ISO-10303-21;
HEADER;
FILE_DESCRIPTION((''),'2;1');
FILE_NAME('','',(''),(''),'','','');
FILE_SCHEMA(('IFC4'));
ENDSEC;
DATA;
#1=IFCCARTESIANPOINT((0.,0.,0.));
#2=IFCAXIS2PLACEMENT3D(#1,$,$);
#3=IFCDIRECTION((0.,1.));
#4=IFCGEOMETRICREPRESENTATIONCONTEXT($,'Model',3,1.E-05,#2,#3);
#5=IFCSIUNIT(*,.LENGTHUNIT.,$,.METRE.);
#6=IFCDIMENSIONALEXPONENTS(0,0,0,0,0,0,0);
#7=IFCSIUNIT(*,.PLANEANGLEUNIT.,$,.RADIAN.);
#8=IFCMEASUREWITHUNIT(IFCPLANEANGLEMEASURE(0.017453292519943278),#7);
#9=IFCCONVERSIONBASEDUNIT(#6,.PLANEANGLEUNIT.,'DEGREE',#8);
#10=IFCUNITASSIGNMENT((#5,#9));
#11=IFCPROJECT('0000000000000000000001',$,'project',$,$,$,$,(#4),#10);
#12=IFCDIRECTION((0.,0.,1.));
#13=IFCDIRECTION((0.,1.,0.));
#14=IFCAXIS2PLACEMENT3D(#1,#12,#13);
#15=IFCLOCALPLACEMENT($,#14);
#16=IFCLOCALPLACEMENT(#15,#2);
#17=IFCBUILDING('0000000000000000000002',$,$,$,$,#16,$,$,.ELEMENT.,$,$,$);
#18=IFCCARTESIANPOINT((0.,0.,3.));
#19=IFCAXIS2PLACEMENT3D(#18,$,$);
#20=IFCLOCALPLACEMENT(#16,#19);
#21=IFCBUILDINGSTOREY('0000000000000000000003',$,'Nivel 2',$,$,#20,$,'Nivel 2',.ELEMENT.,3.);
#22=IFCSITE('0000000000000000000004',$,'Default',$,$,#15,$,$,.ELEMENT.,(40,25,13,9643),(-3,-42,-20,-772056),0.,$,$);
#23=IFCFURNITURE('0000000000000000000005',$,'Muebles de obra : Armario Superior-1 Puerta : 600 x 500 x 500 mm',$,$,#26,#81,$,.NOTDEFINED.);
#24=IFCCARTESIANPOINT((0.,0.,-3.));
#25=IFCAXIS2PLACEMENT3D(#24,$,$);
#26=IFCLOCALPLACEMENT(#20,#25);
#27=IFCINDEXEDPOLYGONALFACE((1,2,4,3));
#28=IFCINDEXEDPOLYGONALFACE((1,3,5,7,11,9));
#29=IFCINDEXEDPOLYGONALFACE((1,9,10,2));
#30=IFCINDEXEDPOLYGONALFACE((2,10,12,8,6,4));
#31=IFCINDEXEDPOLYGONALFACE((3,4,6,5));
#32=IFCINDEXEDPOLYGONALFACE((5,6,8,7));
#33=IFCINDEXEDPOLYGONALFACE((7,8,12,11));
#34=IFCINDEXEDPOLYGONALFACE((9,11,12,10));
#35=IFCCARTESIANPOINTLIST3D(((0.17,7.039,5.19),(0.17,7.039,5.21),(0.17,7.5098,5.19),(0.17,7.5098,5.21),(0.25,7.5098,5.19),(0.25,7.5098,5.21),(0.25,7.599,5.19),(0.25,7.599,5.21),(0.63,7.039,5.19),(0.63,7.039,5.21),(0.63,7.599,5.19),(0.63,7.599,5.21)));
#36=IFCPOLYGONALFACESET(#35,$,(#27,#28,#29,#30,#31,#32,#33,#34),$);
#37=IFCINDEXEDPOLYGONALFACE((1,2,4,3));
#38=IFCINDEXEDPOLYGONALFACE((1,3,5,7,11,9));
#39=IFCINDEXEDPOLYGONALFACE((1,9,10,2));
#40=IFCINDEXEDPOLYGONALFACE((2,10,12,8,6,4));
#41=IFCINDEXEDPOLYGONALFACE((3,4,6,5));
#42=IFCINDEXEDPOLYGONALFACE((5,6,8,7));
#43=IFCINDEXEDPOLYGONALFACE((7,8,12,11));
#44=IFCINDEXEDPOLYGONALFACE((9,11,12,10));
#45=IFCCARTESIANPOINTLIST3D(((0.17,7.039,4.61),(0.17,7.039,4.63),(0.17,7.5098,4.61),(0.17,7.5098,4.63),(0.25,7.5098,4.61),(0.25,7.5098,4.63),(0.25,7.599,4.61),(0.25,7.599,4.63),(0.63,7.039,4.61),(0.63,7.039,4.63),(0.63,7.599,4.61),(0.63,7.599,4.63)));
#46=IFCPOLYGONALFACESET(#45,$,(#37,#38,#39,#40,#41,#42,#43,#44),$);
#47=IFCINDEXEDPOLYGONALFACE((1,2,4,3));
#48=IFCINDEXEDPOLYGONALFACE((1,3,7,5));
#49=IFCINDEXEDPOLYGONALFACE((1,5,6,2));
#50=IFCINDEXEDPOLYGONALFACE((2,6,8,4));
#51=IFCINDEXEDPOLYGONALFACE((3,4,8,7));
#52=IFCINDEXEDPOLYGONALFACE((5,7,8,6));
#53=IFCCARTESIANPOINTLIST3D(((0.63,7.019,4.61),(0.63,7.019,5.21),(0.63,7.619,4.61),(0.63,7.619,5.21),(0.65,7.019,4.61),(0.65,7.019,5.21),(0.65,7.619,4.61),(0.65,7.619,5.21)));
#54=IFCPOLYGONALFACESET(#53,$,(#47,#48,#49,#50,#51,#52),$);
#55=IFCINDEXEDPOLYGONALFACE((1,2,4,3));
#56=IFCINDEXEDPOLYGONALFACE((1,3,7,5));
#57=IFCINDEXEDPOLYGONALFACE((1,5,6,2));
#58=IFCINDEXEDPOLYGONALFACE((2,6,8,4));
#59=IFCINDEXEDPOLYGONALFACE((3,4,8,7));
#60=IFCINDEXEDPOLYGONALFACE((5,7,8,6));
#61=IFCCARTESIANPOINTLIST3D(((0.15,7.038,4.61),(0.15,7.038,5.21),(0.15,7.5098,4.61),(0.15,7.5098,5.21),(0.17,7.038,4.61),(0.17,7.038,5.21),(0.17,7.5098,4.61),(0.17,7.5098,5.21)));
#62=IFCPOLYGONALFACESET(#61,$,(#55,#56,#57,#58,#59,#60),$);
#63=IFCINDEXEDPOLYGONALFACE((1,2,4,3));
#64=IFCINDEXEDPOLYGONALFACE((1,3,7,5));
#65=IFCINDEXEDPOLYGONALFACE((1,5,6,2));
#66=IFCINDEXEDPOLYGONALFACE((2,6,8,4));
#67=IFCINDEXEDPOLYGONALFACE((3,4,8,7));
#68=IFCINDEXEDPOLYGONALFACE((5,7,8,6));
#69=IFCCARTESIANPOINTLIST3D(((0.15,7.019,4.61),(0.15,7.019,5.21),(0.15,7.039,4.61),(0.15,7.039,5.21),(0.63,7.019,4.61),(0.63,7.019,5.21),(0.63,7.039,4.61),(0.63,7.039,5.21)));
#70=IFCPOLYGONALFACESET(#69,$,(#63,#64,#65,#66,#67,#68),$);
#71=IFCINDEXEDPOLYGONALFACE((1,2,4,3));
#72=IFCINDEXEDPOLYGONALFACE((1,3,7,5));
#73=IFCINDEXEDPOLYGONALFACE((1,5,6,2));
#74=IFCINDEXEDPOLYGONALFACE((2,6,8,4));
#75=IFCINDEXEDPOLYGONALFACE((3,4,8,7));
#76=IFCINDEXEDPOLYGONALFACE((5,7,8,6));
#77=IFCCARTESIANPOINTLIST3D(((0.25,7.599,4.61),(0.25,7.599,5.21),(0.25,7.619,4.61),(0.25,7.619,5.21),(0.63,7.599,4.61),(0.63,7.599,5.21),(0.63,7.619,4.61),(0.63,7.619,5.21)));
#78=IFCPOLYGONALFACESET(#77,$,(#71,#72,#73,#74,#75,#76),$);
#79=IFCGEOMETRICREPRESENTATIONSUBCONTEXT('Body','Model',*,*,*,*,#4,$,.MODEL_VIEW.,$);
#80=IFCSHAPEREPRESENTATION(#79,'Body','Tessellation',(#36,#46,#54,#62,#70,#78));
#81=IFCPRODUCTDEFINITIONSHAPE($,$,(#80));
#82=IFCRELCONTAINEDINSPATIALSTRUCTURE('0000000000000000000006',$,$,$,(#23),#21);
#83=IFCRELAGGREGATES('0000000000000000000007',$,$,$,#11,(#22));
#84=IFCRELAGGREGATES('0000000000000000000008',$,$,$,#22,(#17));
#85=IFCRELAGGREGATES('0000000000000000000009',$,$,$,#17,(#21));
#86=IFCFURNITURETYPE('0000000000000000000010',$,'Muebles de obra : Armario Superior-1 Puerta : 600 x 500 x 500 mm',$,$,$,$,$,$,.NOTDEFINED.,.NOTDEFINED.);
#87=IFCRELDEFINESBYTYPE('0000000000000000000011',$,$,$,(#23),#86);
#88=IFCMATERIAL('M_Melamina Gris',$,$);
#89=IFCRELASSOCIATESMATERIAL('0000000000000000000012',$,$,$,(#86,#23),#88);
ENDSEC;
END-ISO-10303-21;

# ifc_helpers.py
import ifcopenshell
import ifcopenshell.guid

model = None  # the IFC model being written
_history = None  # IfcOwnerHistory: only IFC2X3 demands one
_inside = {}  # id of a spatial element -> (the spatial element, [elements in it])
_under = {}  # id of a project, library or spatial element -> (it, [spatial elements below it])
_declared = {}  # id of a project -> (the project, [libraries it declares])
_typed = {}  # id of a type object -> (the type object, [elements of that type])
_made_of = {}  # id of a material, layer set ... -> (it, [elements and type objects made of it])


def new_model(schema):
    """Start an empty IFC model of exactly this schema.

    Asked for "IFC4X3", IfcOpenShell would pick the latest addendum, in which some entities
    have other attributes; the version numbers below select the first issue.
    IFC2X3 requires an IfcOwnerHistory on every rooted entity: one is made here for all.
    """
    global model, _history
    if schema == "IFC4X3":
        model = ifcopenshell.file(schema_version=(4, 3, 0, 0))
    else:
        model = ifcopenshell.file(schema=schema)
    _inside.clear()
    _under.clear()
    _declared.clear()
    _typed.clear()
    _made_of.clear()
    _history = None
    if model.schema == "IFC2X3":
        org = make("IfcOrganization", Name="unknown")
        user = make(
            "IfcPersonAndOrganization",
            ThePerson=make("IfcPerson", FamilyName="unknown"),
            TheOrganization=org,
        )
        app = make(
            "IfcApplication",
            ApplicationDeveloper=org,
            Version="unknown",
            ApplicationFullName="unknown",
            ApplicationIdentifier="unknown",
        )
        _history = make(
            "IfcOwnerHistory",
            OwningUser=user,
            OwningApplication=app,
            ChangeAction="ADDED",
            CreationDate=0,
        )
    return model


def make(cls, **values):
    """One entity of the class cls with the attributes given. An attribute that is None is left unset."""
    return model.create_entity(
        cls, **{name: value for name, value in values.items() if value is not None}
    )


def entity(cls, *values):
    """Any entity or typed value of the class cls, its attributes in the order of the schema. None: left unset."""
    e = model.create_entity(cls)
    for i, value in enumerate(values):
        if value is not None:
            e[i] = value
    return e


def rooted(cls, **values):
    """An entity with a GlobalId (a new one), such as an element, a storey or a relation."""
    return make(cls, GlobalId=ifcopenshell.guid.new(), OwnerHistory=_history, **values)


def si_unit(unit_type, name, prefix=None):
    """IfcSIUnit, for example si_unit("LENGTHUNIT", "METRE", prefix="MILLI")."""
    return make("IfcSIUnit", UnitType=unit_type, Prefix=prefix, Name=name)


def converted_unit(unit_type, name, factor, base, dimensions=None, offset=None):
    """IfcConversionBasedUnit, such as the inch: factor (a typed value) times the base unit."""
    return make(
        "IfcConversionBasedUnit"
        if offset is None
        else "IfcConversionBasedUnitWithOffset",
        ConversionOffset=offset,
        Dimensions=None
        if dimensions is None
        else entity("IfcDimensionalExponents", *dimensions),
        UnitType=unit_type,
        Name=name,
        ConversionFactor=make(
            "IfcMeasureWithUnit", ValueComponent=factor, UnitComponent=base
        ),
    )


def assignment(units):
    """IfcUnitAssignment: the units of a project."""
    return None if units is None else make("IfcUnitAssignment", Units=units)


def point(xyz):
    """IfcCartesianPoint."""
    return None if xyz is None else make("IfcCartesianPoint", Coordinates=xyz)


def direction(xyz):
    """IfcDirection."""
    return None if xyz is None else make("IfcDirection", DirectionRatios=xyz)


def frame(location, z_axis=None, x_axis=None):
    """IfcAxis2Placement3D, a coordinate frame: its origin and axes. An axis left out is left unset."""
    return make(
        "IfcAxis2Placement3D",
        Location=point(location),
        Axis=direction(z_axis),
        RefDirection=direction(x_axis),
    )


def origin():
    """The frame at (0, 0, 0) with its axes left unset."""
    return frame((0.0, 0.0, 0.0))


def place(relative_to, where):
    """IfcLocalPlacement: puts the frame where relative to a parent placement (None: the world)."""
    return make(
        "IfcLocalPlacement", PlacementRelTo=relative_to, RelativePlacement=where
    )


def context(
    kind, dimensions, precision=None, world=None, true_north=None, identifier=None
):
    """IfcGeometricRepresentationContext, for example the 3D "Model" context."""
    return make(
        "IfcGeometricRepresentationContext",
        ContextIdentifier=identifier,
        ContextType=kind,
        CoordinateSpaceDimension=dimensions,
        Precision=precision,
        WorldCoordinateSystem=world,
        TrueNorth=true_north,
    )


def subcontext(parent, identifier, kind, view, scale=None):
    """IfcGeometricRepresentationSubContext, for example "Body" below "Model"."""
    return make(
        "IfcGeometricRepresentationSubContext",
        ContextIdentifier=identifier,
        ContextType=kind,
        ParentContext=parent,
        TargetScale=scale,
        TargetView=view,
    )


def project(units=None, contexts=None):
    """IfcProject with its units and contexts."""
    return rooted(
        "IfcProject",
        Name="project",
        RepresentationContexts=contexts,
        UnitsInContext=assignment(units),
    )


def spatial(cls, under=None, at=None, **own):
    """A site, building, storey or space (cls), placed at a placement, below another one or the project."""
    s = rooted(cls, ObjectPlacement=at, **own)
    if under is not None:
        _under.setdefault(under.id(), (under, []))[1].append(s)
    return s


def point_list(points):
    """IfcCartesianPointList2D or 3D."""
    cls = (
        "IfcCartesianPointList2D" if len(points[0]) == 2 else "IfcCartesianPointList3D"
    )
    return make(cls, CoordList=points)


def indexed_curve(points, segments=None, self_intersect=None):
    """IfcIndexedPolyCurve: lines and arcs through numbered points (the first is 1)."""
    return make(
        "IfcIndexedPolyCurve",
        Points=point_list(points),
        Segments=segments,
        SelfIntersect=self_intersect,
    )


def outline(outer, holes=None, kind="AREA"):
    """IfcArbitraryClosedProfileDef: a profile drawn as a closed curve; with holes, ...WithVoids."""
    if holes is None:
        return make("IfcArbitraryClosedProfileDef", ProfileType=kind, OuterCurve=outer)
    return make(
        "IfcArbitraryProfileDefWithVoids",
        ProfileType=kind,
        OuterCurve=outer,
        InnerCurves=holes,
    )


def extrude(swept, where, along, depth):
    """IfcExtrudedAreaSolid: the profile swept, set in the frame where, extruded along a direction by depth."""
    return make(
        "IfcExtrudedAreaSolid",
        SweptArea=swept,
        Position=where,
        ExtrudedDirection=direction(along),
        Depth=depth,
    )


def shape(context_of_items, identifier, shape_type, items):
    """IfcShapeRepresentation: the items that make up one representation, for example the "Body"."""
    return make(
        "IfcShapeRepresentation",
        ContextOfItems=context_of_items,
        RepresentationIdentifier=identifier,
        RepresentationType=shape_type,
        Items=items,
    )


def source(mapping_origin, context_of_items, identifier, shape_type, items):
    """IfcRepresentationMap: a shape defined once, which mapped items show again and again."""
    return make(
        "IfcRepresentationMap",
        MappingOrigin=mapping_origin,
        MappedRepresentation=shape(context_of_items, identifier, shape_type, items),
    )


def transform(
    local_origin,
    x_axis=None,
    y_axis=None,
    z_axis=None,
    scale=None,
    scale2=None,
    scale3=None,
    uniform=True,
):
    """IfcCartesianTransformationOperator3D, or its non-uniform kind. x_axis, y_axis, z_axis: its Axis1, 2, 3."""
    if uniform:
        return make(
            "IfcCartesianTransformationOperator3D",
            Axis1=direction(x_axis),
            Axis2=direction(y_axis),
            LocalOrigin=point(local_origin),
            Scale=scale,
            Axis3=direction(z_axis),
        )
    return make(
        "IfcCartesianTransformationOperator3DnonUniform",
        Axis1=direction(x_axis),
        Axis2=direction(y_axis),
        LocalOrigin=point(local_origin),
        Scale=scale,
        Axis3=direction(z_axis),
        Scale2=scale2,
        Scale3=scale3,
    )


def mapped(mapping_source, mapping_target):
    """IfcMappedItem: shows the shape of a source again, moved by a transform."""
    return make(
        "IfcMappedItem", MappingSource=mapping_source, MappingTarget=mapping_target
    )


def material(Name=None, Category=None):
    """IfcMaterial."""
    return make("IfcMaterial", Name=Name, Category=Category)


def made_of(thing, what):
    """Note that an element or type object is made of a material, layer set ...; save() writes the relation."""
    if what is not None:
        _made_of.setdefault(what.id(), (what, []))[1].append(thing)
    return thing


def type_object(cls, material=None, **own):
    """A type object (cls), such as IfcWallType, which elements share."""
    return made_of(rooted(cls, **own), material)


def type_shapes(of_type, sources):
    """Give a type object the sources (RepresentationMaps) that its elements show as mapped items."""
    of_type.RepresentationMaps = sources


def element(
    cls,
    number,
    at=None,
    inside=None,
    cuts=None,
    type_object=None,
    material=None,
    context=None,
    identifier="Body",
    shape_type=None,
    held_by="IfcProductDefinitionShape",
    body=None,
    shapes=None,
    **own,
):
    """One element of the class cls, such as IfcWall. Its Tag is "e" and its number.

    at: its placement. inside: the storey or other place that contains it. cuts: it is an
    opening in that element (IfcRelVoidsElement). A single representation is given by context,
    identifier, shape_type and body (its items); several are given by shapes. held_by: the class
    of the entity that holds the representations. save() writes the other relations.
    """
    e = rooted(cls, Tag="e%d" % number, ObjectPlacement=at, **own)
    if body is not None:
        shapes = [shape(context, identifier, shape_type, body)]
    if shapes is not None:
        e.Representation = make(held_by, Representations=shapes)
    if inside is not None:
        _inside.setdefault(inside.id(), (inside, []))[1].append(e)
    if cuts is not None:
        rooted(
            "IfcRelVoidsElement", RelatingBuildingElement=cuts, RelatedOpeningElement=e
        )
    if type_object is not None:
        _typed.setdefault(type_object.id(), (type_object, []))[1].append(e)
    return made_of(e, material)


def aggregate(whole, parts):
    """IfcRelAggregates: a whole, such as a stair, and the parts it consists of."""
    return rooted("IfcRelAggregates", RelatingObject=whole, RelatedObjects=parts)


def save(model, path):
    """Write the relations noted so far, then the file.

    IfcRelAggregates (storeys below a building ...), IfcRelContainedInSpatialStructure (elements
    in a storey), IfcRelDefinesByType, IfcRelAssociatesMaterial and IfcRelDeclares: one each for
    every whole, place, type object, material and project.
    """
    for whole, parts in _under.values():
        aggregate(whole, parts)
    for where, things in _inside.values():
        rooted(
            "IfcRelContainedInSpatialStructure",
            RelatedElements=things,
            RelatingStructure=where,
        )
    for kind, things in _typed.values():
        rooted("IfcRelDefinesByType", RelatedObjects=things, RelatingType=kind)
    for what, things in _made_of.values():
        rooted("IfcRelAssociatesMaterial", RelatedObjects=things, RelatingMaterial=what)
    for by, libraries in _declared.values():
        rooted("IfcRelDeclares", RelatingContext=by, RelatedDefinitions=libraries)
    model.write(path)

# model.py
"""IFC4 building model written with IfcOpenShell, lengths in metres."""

from ifc_helpers import new_model, entity, si_unit, converted_unit, direction, frame, origin, place, context, subcontext, project, spatial, indexed_curve, outline, extrude, source, transform, mapped, material, type_object, type_shapes, element, save


model = new_model("IFC4")

# Units and contexts
model_context = context("Model", 3, precision=1e-05, world=origin(), true_north=direction((0.0, 1.0)))
body_context = subcontext(model_context, "Body", "Model", "MODEL_VIEW")
ifc_project = project(units=[si_unit("LENGTHUNIT", "METRE"), converted_unit("PLANEANGLEUNIT", "DEGREE", entity("IfcPlaneAngleMeasure", 0.017453292519943278), si_unit("PLANEANGLEUNIT", "RADIAN"), dimensions=[0, 0, 0, 0, 0, 0, 0])], contexts=[model_context])

# Site, building, storey
site_placement = place(None, frame((0.0, 0.0, 0.0), z_axis=(0.0, 0.0, 1.0), x_axis=(0.0, 1.0, 0.0)))
site = spatial("IfcSite", under=ifc_project, at=site_placement, Name="Default", CompositionType="ELEMENT", RefLatitude=(40, 25, 13, 9643), RefLongitude=(-3, -42, -20, -772056), RefElevation=0.0)
building_placement = place(site_placement, origin())
building = spatial("IfcBuilding", under=site, at=building_placement, CompositionType="ELEMENT")
storey_placement = place(building_placement, frame((0.0, 0.0, 3.0)))
storey = spatial("IfcBuildingStorey", under=building, at=storey_placement, Name="Nivel 2", LongName="Nivel 2", CompositionType="ELEMENT", Elevation=3.0)

# Furniture
ifc_material_1 = material(Name="M_Melamina Gris")
furniture_type_1 = type_object("IfcFurnitureType", Name="Muebles de obra : Armario Superior-1 Puerta : 600 x 500 x 500 mm", AssemblyPlace="NOTDEFINED", PredefinedType="NOTDEFINED", material=ifc_material_1)
shared_shape_1 = source(origin(), body_context, "Body", "SweptSolid", [
    extrude(outline(indexed_curve([(-0.28, -0.2164), (0.1, -0.2164), (0.1, -0.1272), (0.18, -0.1272), (0.18, 0.3436), (-0.28, 0.3436), (-0.28, -0.2164)], self_intersect=False)), frame((0.35, 7.3826, 5.19), z_axis=(0.0, 0.0, 1.0), x_axis=(-1.0, 0.0, 0.0)), (0.0, 0.0, 1.0), 0.02),
    extrude(outline(indexed_curve([(-0.28, -0.2164), (0.1, -0.2164), (0.1, -0.1272), (0.18, -0.1272), (0.18, 0.3436), (-0.28, 0.3436), (-0.28, -0.2164)], self_intersect=False)), frame((0.35, 7.3826, 4.61), z_axis=(0.0, 0.0, 1.0), x_axis=(-1.0, 0.0, 0.0)), (0.0, 0.0, 1.0), 0.02),
    extrude(outline(indexed_curve([(-0.3, -0.01), (0.3, -0.01), (0.3, 0.01), (-0.3, 0.01), (-0.3, -0.01)], self_intersect=False)), frame((0.64, 7.319, 4.61), z_axis=(0.0, 0.0, 1.0), x_axis=(0.0, -1.0, 0.0)), (0.0, 0.0, 1.0), 0.6),
    extrude(outline(indexed_curve([(-0.2359, -0.01), (0.2359, -0.01), (0.2359, 0.01), (-0.2359, 0.01), (-0.2359, -0.01)], self_intersect=False)), frame((0.16, 7.2739, 4.61), z_axis=(0.0, 0.0, 1.0), x_axis=(0.0, 1.0, 0.0)), (0.0, 0.0, 1.0), 0.6),
    extrude(outline(indexed_curve([(-0.24, -0.01), (0.24, -0.01), (0.24, 0.01), (-0.24, 0.01), (-0.24, -0.01)], self_intersect=False)), frame((0.39, 7.029, 4.61), z_axis=(0.0, 0.0, 1.0), x_axis=(-1.0, 0.0, 0.0)), (0.0, 0.0, 1.0), 0.6),
    extrude(outline(indexed_curve([(-0.19, -0.01), (0.19, -0.01), (0.19, 0.01), (-0.19, 0.01), (-0.19, -0.01)], self_intersect=False)), frame((0.44, 7.609, 4.61), z_axis=(0.0, 0.0, 1.0), x_axis=(-1.0, 0.0, 0.0)), (0.0, 0.0, 1.0), 0.6),
])
type_shapes(furniture_type_1, [shared_shape_1])
furniture_1_placement = place(storey_placement, frame((0.0, 0.0, -3.0)))
element("IfcFurniture", 1, at=furniture_1_placement, inside=storey, type_object=furniture_type_1, material=ifc_material_1, Name="Muebles de obra : Armario Superior-1 Puerta : 600 x 500 x 500 mm", PredefinedType="NOTDEFINED", context=body_context, shape_type="MappedRepresentation", body=[
    mapped(shared_shape_1, transform((0.0, 0.0, 0.0), scale=1.0)),
])

save(model, "model.ifc")
